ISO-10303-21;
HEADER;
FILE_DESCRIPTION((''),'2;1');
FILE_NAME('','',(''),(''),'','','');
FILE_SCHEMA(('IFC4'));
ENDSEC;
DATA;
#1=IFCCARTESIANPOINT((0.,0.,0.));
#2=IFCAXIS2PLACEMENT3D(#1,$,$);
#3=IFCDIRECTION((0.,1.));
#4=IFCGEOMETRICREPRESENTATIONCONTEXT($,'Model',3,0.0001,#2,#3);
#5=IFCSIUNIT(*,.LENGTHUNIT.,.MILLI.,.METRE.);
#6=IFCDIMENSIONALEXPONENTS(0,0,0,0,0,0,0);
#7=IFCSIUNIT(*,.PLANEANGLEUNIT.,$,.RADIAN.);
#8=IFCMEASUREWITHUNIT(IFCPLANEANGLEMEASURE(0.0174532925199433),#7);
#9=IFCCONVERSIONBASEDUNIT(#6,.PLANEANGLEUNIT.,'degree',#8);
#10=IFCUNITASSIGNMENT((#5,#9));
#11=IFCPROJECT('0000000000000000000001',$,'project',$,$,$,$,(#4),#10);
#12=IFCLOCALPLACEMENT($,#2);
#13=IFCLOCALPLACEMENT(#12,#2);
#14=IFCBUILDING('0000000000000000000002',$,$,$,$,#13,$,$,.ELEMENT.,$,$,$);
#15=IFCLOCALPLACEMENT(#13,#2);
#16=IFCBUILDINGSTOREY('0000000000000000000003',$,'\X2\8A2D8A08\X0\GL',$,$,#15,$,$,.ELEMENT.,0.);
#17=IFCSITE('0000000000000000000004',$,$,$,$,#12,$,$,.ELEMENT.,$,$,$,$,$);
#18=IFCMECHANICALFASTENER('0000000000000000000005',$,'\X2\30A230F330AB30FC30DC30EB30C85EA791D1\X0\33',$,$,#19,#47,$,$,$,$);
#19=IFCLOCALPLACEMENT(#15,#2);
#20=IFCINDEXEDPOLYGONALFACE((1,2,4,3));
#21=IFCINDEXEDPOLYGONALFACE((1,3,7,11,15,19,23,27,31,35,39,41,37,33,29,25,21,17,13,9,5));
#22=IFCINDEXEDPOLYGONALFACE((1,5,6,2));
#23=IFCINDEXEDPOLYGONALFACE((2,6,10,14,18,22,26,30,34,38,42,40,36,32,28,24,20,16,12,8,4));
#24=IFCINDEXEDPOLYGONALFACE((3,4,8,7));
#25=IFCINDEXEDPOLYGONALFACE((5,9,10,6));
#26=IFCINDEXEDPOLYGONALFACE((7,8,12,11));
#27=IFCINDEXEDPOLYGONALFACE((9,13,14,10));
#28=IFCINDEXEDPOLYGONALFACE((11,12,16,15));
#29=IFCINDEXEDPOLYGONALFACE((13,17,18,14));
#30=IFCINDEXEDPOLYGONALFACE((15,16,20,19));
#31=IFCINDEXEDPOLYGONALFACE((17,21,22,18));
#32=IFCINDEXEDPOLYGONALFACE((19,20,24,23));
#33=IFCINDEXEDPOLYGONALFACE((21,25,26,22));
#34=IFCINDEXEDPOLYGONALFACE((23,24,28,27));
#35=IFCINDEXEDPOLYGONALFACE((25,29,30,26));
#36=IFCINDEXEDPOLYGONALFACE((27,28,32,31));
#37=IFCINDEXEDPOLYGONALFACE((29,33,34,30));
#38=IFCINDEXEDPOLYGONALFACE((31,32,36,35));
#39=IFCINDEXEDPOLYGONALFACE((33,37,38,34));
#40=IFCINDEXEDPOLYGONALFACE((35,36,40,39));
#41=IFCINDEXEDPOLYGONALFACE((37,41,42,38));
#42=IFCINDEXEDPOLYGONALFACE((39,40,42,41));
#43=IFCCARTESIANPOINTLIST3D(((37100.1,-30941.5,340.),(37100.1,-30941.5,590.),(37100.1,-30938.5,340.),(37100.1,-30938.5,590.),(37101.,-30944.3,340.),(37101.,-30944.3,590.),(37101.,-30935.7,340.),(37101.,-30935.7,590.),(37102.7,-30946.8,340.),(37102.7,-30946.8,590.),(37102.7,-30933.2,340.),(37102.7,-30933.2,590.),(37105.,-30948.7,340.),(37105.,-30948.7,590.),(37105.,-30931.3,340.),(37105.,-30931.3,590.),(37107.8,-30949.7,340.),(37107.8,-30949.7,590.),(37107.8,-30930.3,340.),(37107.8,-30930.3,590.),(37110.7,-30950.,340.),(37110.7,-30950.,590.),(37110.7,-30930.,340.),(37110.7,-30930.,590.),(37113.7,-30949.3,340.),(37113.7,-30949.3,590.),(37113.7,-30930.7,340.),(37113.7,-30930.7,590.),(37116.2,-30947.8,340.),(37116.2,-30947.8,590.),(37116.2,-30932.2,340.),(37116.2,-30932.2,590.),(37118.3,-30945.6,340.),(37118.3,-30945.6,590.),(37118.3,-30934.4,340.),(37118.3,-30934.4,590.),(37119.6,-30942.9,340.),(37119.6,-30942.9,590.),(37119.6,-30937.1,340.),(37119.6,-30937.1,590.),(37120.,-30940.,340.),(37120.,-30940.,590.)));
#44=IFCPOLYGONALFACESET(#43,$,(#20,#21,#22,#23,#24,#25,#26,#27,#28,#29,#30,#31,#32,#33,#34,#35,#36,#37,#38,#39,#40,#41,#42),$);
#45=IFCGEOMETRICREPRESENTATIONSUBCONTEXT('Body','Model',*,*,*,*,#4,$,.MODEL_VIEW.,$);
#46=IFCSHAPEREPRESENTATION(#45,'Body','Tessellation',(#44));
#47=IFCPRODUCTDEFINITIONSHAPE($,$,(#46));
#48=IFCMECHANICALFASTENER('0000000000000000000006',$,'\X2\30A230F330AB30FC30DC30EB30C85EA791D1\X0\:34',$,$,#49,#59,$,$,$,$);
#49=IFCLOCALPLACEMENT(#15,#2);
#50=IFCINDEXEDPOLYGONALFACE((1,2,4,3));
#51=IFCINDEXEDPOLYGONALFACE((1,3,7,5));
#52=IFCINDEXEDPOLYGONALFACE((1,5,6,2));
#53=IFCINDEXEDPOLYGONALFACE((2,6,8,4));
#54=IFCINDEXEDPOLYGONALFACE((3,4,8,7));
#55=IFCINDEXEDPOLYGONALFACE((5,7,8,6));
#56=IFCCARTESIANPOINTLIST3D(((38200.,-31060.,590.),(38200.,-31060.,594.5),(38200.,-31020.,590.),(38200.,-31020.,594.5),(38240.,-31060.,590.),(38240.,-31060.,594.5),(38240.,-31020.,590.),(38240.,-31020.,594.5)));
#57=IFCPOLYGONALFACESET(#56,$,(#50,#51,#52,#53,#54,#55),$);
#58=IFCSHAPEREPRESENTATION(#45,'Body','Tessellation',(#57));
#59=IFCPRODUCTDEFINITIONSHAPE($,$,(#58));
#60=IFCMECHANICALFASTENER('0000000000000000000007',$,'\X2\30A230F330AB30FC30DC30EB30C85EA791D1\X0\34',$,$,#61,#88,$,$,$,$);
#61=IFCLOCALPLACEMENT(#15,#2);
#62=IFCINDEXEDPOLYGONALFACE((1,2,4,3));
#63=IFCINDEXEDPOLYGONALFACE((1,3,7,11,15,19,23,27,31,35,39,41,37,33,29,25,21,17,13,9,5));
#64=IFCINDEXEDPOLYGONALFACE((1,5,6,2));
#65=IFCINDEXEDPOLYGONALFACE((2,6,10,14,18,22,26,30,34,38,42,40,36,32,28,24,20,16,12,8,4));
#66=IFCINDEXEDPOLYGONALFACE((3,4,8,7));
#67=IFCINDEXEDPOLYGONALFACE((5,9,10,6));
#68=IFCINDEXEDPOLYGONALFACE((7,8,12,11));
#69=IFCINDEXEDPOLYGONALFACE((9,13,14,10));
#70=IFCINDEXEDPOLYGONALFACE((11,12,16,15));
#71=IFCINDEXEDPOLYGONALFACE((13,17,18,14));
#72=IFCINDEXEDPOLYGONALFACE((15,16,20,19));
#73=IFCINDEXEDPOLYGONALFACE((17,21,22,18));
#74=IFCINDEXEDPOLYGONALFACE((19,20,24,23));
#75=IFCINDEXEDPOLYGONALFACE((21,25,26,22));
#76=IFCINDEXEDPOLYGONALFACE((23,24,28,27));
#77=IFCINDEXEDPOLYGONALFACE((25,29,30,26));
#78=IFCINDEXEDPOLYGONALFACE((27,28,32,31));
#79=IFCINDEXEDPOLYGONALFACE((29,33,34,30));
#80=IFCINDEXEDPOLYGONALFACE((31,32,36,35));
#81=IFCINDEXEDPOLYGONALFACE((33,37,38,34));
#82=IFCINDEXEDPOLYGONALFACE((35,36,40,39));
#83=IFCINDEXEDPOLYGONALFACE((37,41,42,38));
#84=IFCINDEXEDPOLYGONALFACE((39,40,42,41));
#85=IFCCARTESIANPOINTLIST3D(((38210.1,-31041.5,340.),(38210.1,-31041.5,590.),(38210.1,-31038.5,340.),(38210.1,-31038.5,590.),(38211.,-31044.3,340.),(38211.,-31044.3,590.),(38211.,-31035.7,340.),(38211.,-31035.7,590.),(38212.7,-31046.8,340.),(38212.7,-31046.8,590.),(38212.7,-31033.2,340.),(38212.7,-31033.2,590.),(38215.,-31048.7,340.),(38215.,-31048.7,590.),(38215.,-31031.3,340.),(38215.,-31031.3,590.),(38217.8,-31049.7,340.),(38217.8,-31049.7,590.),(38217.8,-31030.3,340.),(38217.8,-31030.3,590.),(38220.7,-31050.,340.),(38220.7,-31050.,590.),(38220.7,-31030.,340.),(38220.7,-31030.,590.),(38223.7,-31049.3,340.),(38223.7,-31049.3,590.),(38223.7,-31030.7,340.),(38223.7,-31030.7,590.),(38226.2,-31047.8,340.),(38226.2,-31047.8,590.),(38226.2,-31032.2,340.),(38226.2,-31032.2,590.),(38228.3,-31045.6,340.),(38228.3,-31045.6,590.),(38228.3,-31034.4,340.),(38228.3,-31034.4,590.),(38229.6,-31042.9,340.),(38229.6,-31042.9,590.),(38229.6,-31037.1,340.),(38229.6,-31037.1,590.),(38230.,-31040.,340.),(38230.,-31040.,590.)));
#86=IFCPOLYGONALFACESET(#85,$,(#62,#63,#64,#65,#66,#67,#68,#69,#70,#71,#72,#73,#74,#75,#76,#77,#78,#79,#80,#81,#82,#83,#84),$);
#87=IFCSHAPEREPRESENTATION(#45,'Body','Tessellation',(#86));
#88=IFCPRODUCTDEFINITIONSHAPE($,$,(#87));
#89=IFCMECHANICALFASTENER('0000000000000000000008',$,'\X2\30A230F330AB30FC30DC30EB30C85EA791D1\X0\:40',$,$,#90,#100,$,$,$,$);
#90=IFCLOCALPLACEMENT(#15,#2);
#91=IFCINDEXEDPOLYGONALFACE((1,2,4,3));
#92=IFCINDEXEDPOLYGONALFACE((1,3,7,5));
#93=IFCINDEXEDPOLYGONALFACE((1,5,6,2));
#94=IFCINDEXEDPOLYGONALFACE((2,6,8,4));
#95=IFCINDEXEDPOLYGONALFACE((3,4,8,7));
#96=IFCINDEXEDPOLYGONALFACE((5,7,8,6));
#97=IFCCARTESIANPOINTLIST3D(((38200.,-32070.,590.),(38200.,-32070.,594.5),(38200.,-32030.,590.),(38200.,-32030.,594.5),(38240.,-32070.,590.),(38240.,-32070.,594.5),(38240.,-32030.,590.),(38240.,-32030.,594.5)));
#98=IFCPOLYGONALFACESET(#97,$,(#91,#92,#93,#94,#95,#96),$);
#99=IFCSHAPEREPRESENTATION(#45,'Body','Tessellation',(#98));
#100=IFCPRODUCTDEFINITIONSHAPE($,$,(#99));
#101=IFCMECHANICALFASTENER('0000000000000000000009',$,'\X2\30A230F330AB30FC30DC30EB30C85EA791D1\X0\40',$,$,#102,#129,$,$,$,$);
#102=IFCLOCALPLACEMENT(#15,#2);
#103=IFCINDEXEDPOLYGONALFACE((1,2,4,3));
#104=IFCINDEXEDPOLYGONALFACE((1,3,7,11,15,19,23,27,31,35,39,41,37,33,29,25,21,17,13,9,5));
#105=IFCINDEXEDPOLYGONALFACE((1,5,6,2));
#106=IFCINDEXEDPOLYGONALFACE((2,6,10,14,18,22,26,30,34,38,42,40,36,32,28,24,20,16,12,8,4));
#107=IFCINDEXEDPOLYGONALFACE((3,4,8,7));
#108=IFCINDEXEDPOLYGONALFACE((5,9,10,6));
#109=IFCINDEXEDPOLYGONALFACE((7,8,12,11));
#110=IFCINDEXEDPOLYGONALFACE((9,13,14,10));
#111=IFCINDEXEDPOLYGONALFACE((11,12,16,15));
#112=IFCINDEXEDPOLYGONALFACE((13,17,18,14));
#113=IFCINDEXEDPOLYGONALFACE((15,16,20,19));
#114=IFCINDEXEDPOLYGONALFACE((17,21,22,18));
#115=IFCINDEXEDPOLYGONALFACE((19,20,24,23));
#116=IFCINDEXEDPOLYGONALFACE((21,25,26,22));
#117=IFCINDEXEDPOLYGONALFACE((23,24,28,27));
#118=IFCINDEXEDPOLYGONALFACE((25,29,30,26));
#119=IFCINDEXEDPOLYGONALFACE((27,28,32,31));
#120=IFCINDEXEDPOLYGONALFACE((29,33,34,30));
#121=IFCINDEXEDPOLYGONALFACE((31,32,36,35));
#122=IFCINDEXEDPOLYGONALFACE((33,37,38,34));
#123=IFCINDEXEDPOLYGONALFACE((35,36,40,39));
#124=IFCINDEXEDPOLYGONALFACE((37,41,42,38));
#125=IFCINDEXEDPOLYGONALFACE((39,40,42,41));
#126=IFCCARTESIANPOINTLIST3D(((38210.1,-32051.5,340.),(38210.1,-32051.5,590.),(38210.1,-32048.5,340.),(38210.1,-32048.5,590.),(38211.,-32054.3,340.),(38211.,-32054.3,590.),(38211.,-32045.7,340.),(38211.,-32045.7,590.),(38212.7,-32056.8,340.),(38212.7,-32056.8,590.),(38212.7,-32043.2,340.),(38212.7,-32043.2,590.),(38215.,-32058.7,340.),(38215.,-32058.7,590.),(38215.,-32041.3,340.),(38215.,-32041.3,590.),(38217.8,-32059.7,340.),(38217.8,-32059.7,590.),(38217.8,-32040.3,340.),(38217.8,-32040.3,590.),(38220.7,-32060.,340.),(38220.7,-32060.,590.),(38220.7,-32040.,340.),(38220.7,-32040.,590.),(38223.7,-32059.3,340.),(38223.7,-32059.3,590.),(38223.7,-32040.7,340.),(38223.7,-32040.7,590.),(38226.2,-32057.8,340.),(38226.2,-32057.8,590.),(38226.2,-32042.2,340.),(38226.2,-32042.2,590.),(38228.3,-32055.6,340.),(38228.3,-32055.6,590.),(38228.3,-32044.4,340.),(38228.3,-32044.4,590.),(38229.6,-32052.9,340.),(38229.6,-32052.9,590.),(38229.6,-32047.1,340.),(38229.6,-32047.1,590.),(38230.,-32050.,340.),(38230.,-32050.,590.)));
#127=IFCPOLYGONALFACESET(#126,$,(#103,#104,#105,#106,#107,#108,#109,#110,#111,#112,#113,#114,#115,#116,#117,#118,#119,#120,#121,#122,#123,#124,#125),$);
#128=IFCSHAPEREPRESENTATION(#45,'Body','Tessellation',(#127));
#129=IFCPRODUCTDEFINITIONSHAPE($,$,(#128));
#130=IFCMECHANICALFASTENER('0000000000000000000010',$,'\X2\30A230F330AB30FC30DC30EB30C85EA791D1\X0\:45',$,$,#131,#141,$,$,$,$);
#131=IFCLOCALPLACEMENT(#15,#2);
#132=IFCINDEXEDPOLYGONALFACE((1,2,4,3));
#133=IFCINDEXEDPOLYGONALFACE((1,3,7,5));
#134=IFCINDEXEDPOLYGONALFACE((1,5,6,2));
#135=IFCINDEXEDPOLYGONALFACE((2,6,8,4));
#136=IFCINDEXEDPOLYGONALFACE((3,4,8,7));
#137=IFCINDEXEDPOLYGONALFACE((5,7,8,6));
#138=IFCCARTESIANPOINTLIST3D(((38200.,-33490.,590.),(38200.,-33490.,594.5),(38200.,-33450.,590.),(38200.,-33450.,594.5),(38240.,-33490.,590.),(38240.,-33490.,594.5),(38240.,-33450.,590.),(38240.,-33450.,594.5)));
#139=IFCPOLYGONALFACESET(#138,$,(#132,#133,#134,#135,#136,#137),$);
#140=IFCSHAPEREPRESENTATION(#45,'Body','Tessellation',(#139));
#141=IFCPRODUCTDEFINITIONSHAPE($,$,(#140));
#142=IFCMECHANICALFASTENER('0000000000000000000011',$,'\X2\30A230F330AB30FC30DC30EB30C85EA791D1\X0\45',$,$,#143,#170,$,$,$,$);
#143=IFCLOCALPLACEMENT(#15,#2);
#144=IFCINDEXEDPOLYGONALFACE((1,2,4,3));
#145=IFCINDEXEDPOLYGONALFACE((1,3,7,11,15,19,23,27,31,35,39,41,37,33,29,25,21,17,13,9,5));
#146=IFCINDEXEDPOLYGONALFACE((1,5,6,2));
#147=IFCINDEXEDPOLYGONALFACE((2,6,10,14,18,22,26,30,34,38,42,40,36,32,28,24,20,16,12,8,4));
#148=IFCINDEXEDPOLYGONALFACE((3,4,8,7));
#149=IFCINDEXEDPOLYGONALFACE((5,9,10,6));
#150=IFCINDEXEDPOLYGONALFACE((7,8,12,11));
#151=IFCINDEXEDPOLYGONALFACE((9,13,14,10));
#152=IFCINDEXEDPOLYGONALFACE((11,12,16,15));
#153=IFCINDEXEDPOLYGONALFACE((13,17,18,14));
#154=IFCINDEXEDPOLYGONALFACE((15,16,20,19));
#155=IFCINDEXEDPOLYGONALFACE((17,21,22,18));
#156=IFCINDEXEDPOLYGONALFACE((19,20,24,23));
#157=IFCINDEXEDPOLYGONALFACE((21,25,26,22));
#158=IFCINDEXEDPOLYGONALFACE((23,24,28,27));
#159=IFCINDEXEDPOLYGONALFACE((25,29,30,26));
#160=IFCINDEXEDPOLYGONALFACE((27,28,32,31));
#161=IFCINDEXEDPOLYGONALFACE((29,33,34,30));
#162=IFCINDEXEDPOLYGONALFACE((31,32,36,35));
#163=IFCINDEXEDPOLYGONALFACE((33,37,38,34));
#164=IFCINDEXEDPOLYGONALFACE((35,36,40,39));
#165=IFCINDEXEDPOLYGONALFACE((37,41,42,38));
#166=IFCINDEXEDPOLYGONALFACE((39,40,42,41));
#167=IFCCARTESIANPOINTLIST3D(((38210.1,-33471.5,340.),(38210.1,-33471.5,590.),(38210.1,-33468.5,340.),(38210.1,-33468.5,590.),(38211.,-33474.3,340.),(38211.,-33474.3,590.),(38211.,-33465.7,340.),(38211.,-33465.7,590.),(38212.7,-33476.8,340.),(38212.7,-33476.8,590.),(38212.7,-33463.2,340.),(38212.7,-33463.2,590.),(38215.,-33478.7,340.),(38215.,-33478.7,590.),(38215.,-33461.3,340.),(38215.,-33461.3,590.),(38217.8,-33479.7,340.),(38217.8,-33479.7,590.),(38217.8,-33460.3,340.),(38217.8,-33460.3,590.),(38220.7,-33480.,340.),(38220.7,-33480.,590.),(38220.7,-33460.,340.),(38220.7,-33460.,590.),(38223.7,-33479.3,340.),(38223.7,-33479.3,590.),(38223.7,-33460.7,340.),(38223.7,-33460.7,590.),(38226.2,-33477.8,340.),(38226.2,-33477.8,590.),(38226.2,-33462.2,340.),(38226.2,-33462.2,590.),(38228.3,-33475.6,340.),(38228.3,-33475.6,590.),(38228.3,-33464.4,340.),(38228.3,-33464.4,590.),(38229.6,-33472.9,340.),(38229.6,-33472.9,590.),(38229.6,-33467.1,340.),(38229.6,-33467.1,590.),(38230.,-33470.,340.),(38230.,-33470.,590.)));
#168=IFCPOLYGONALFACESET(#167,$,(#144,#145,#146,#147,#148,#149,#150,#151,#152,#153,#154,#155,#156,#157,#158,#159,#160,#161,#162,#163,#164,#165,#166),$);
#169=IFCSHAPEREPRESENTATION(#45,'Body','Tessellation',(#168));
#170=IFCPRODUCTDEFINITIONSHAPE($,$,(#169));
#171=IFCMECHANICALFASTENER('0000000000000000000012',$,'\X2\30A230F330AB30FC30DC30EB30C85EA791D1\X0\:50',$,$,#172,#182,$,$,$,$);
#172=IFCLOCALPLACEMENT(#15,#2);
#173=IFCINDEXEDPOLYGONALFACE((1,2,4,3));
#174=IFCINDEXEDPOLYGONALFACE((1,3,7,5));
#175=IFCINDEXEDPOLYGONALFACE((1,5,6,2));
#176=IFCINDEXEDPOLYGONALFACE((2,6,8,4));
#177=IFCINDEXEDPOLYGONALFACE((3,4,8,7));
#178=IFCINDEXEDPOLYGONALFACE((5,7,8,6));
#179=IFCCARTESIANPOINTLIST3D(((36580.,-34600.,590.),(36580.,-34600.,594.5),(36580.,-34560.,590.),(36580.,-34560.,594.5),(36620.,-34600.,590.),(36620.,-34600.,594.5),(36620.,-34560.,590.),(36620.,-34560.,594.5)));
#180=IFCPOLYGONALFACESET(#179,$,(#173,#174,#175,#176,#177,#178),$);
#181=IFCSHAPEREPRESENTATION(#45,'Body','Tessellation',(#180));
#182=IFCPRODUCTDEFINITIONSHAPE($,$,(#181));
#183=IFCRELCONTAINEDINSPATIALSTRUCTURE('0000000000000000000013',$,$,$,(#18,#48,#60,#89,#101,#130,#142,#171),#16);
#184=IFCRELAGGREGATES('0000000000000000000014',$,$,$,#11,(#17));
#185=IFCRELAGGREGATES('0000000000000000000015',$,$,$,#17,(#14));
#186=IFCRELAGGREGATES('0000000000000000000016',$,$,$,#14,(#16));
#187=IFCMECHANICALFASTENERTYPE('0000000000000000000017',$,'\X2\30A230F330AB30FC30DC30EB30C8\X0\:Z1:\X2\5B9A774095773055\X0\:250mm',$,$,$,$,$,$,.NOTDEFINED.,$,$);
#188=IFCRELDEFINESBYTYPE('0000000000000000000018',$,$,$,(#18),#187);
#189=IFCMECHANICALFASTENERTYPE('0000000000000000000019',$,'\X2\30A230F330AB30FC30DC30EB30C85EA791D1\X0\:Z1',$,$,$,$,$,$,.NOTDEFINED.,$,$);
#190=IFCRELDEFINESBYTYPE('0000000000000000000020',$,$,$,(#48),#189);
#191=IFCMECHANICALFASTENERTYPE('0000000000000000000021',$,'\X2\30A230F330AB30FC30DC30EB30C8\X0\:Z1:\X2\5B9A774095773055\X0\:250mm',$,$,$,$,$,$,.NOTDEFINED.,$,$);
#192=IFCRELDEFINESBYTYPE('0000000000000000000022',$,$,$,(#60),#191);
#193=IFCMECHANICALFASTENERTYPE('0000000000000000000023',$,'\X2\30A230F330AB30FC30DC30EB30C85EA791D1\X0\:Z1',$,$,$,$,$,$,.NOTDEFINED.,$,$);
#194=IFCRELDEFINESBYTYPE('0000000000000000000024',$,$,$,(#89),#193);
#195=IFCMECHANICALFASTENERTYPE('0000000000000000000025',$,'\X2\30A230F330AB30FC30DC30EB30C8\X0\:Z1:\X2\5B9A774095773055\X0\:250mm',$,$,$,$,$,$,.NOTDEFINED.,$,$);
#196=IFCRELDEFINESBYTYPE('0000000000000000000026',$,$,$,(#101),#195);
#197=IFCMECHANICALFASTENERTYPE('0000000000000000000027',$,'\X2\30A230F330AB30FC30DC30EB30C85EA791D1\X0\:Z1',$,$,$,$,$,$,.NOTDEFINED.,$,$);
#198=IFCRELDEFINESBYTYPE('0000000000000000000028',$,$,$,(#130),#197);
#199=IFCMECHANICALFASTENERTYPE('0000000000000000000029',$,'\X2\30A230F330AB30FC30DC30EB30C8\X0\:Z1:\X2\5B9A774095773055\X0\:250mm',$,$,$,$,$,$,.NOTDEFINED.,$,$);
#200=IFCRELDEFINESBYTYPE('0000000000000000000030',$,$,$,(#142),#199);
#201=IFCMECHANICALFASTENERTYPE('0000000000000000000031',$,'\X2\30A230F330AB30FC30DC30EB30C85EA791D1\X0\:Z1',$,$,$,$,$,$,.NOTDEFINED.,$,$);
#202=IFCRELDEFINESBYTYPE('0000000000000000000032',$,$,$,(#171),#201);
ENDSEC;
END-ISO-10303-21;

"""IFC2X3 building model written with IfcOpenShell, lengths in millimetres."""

from ifc_helpers import new_model, entity, si_unit, converted_unit, direction, frame, origin, origin_with_axes, origin_2d, place, context, subcontext, project, spatial, rectangle, circle, extrude, type_object, element, save


model = new_model("IFC2X3")

# Units and contexts
model_context = context("Model", 3, precision=0.0001, world=origin(), true_north=direction((0.0, 1.0)))
body_context = subcontext(model_context, "Body", "Model", "MODEL_VIEW")
ifc_project = project(units=[si_unit("LENGTHUNIT", "METRE", prefix="MILLI"), converted_unit("PLANEANGLEUNIT", "degree", entity("IfcPlaneAngleMeasure", 0.0174532925199433), si_unit("PLANEANGLEUNIT", "RADIAN"), dimensions=[0, 0, 0, 0, 0, 0, 0])], contexts=[model_context])

# Site, building, storey
site_placement = place(None, origin())
site = spatial("IfcSite", under=ifc_project, at=site_placement, CompositionType="ELEMENT")
building_placement = place(site_placement, origin())
building = spatial("IfcBuilding", under=site, at=building_placement, CompositionType="ELEMENT")
storey_placement = place(building_placement, origin())
storey = spatial("IfcBuildingStorey", under=building, at=storey_placement, Name="設計GL", CompositionType="ELEMENT", Elevation=0.0)

# Mechanical fasteners
mechanical_fastener_type_1 = type_object("IfcMechanicalFastenerType", Name="アンカーボルト:Z1:定着長さ:250mm")
mechanical_fastener_1_placement = place(storey_placement, frame((37110.0, -30940.0, 340.0)))
element("IfcMechanicalFastener", 1, at=mechanical_fastener_1_placement, inside=storey, type_object=mechanical_fastener_type_1, Name="アンカーボルト座金33", context=body_context, shape_type="SweptSolid", body=[
    extrude(circle(Radius=10.0, at=origin_2d()), origin_with_axes(), (0.0, 0.0, 1.0), 250.0),
])
mechanical_fastener_type_2 = type_object("IfcMechanicalFastenerType", Name="アンカーボルト座金:Z1")
mechanical_fastener_2_placement = place(storey_placement, frame((38220.0, -31040.0, 590.0)))
element("IfcMechanicalFastener", 2, at=mechanical_fastener_2_placement, inside=storey, type_object=mechanical_fastener_type_2, Name="アンカーボルト座金:34", context=body_context, shape_type="SweptSolid", body=[
    extrude(rectangle(XDim=40.0, YDim=40.0, at=origin_2d()), origin_with_axes(), (0.0, 0.0, 1.0), 4.5),
])
mechanical_fastener_type_3 = type_object("IfcMechanicalFastenerType", Name="アンカーボルト:Z1:定着長さ:250mm")
mechanical_fastener_3_placement = place(storey_placement, frame((38220.0, -31040.0, 340.0)))
element("IfcMechanicalFastener", 3, at=mechanical_fastener_3_placement, inside=storey, type_object=mechanical_fastener_type_3, Name="アンカーボルト座金34", context=body_context, shape_type="SweptSolid", body=[
    extrude(circle(Radius=10.0, at=origin_2d()), origin_with_axes(), (0.0, 0.0, 1.0), 250.0),
])
mechanical_fastener_type_4 = type_object("IfcMechanicalFastenerType", Name="アンカーボルト座金:Z1")
mechanical_fastener_4_placement = place(storey_placement, frame((38220.0, -32050.0, 590.0)))
element("IfcMechanicalFastener", 4, at=mechanical_fastener_4_placement, inside=storey, type_object=mechanical_fastener_type_4, Name="アンカーボルト座金:40", context=body_context, shape_type="SweptSolid", body=[
    extrude(rectangle(XDim=40.0, YDim=40.0, at=origin_2d()), origin_with_axes(), (0.0, 0.0, 1.0), 4.5),
])
mechanical_fastener_type_5 = type_object("IfcMechanicalFastenerType", Name="アンカーボルト:Z1:定着長さ:250mm")
mechanical_fastener_5_placement = place(storey_placement, frame((38220.0, -32050.0, 340.0)))
element("IfcMechanicalFastener", 5, at=mechanical_fastener_5_placement, inside=storey, type_object=mechanical_fastener_type_5, Name="アンカーボルト座金40", context=body_context, shape_type="SweptSolid", body=[
    extrude(circle(Radius=10.0, at=origin_2d()), origin_with_axes(), (0.0, 0.0, 1.0), 250.0),
])
mechanical_fastener_type_6 = type_object("IfcMechanicalFastenerType", Name="アンカーボルト座金:Z1")
mechanical_fastener_6_placement = place(storey_placement, frame((38220.0, -33470.0, 590.0)))
element("IfcMechanicalFastener", 6, at=mechanical_fastener_6_placement, inside=storey, type_object=mechanical_fastener_type_6, Name="アンカーボルト座金:45", context=body_context, shape_type="SweptSolid", body=[
    extrude(rectangle(XDim=40.0, YDim=40.0, at=origin_2d()), origin_with_axes(), (0.0, 0.0, 1.0), 4.5),
])
mechanical_fastener_type_7 = type_object("IfcMechanicalFastenerType", Name="アンカーボルト:Z1:定着長さ:250mm")
mechanical_fastener_7_placement = place(storey_placement, frame((38220.0, -33470.0, 340.0)))
element("IfcMechanicalFastener", 7, at=mechanical_fastener_7_placement, inside=storey, type_object=mechanical_fastener_type_7, Name="アンカーボルト座金45", context=body_context, shape_type="SweptSolid", body=[
    extrude(circle(Radius=10.0, at=origin_2d()), origin_with_axes(), (0.0, 0.0, 1.0), 250.0),
])
mechanical_fastener_type_8 = type_object("IfcMechanicalFastenerType", Name="アンカーボルト座金:Z1")
mechanical_fastener_8_placement = place(storey_placement, frame((36600.0, -34580.0, 590.0)))
element("IfcMechanicalFastener", 8, at=mechanical_fastener_8_placement, inside=storey, type_object=mechanical_fastener_type_8, Name="アンカーボルト座金:50", context=body_context, shape_type="SweptSolid", body=[
    extrude(rectangle(XDim=40.0, YDim=40.0, at=origin_2d()), origin_with_axes(), (0.0, 0.0, 1.0), 4.5),
])

save(model, "model.ifc")
